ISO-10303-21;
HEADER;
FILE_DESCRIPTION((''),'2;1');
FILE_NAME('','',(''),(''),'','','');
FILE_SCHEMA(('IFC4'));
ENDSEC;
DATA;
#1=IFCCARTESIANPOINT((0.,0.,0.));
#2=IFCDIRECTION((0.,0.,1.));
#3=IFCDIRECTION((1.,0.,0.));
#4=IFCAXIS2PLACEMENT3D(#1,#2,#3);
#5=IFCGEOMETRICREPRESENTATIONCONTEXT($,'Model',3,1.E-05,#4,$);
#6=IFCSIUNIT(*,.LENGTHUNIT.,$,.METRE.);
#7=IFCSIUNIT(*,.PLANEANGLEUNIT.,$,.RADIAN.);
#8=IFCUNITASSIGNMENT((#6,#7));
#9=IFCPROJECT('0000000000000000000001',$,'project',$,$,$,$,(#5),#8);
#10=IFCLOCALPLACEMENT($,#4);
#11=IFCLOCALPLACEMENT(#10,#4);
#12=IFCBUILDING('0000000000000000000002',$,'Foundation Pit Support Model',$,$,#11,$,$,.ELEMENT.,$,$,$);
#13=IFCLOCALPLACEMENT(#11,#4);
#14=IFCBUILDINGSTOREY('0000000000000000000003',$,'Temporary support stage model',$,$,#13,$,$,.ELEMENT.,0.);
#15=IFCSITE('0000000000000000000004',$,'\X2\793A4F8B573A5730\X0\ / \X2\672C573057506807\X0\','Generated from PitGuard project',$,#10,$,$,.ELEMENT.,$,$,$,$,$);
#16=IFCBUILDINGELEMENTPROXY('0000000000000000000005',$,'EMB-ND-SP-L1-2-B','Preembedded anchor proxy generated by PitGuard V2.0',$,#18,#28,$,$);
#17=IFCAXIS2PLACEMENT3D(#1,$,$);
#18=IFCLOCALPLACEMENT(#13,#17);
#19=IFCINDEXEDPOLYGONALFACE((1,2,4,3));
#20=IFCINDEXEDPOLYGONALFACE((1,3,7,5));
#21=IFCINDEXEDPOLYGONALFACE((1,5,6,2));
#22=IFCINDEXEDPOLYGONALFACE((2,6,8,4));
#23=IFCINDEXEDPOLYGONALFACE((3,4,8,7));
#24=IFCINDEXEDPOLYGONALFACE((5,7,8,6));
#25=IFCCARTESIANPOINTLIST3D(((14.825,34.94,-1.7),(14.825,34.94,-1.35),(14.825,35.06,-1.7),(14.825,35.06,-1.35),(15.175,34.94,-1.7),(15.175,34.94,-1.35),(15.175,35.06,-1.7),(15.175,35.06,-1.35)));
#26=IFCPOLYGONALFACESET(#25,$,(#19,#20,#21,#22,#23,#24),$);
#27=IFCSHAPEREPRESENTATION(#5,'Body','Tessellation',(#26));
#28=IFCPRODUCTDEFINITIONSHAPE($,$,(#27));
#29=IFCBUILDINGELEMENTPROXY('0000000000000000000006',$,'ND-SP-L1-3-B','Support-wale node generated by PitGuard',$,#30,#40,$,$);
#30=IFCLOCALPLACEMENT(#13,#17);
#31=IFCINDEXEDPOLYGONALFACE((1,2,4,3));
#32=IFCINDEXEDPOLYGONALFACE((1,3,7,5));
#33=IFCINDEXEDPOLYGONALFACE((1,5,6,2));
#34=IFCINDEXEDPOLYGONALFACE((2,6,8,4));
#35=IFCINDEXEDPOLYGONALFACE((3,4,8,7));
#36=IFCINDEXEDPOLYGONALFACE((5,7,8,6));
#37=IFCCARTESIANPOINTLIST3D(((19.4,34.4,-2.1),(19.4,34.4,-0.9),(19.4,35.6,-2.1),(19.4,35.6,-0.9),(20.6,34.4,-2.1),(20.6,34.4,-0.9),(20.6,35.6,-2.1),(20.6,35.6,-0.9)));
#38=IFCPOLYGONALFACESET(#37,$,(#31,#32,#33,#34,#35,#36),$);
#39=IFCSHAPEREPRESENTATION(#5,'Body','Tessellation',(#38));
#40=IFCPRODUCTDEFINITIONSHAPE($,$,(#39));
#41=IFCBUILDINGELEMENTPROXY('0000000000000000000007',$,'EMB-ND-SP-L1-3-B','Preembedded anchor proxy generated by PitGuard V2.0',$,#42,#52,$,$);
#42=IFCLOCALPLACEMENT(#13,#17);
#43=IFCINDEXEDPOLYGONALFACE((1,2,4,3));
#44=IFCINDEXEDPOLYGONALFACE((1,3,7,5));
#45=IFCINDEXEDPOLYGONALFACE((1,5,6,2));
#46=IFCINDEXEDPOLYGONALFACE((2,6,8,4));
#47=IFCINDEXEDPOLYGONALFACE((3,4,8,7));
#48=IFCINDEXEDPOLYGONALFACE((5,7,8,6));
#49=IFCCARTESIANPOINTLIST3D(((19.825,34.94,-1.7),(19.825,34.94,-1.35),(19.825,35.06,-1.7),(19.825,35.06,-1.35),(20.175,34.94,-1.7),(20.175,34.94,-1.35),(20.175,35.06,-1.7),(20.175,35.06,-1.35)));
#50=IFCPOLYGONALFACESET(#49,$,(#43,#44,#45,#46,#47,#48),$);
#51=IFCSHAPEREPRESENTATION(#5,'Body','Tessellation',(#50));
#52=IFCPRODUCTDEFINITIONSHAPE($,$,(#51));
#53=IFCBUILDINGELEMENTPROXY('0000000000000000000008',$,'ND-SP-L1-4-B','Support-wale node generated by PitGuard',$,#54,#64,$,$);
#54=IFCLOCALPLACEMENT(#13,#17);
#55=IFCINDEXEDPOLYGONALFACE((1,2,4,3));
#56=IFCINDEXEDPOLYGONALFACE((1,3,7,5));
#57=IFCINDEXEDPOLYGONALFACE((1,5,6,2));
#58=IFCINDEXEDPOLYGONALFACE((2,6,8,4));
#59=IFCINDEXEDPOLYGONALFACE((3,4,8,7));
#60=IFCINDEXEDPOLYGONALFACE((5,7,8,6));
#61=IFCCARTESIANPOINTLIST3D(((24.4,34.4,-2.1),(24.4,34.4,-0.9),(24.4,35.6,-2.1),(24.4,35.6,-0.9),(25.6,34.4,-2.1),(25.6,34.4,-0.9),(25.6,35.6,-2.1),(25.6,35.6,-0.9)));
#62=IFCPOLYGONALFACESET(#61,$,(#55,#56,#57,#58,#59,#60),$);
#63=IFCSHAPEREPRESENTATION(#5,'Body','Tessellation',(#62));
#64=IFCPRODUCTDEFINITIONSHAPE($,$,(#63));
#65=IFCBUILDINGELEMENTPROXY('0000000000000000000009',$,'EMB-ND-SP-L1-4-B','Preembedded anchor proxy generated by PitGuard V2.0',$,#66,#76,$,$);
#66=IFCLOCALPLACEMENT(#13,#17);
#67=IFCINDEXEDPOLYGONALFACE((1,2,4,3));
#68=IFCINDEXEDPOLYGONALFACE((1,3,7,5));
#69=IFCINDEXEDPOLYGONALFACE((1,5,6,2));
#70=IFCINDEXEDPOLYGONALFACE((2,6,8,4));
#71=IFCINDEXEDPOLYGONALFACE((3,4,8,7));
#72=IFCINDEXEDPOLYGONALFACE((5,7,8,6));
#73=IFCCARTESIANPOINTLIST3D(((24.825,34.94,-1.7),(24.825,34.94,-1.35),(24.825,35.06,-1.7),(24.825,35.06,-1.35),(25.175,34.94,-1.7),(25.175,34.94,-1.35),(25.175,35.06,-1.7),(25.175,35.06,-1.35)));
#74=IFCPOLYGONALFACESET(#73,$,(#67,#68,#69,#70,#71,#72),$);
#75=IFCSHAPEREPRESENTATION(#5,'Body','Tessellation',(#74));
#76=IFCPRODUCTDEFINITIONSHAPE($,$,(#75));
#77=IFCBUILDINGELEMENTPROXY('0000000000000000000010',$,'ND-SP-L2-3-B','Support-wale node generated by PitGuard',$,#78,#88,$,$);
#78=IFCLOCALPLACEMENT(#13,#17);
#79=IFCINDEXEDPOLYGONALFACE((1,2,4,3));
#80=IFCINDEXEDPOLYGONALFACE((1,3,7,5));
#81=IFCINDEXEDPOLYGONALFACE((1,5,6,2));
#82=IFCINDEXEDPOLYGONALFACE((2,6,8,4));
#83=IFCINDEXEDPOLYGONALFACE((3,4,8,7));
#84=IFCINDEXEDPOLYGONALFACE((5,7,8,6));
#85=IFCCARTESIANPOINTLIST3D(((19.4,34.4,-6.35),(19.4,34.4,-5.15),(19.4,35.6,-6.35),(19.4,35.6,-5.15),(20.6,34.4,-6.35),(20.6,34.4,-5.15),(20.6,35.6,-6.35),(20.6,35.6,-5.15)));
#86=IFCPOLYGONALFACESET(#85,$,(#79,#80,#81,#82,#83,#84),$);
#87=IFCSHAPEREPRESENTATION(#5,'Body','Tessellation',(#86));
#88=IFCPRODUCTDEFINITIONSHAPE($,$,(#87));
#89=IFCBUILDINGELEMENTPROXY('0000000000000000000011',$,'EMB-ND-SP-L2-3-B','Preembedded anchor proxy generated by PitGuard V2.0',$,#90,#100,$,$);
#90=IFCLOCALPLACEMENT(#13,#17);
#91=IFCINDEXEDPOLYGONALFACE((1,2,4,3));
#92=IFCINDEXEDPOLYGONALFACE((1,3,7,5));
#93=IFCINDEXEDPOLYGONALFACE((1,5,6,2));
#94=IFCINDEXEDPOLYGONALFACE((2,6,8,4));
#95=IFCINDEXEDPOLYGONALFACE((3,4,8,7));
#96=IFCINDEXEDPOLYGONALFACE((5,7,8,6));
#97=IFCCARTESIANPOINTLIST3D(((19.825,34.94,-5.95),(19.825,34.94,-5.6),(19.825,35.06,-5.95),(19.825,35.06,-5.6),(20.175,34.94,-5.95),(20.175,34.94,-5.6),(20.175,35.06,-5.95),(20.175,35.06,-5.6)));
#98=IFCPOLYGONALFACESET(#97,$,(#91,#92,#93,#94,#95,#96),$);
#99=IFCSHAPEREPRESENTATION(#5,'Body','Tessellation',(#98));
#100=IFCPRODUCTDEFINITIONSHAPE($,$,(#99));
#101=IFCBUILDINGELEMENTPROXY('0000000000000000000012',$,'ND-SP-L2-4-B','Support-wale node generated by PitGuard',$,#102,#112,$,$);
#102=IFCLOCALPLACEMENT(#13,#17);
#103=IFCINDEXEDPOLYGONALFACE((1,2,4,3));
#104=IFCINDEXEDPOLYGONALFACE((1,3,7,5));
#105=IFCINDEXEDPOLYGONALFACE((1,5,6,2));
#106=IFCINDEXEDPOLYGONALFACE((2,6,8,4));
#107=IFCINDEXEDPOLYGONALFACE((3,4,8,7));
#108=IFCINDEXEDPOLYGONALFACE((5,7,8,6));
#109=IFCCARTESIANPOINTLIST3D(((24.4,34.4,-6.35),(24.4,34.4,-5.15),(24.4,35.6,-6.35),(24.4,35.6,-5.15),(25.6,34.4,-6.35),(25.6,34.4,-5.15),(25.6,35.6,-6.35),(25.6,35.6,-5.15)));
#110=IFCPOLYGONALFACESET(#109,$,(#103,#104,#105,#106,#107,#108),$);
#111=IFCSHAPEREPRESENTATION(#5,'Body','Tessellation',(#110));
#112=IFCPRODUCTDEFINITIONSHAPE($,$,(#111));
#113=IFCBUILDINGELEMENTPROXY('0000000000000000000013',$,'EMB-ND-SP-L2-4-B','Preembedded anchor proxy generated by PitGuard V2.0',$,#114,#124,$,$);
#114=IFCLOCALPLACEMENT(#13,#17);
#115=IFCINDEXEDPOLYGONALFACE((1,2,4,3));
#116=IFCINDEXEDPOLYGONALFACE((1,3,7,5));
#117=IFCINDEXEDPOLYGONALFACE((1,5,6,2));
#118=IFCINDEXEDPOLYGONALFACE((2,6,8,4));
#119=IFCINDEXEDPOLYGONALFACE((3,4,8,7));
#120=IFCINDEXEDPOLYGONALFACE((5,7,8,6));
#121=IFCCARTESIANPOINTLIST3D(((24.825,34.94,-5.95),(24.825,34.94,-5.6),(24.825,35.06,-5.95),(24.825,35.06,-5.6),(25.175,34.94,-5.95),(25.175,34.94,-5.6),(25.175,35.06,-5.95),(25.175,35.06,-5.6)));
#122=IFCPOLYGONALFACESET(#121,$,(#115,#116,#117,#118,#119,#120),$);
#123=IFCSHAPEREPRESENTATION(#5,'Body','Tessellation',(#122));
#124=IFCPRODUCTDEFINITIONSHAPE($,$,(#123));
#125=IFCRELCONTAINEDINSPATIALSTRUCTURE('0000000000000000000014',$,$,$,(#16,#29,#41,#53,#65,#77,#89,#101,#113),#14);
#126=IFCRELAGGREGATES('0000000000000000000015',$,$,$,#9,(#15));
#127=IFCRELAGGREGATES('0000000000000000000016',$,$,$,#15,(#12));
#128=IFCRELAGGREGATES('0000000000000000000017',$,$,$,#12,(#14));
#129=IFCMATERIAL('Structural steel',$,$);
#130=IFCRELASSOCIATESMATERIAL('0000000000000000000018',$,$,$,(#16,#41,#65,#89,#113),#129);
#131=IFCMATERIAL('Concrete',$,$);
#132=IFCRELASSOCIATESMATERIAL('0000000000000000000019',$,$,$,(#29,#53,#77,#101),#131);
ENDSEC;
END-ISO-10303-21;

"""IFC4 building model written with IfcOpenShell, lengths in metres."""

from ifc_helpers import new_model, si_unit, frame, origin_with_axes, origin_2d, place, context, project, spatial, rectangle, extrude, material, element, save


model = new_model("IFC4")

# Units and contexts
model_context = context("Model", 3, precision=1e-05, world=origin_with_axes())
ifc_project = project(units=[si_unit("LENGTHUNIT", "METRE"), si_unit("PLANEANGLEUNIT", "RADIAN")], contexts=[model_context])

# Site, building, storey
site_placement = place(None, origin_with_axes())
site = spatial("IfcSite", under=ifc_project, at=site_placement, Name="示例场地 / 本地坐标", Description="Generated from PitGuard project", CompositionType="ELEMENT")
building_placement = place(site_placement, origin_with_axes())
building = spatial("IfcBuilding", under=site, at=building_placement, Name="Foundation Pit Support Model", CompositionType="ELEMENT")
storey_placement = place(building_placement, origin_with_axes())
storey = spatial("IfcBuildingStorey", under=building, at=storey_placement, Name="Temporary support stage model", CompositionType="ELEMENT", Elevation=0.0)

# Shared definitions
ifc_material_1 = material(Name="Concrete")

# Shared definitions
ifc_material_2 = material(Name="Structural steel")

# Building element proxies
proxy_1_placement = place(storey_placement, frame((15.0, 35.0, -1.7), z_axis=(0.0, 0.0, 1.0), x_axis=(1.0, 0.0, 0.0)))
element("IfcBuildingElementProxy", 1, at=proxy_1_placement, inside=storey, material=ifc_material_2, Name="EMB-ND-SP-L1-2-B", Description="Preembedded anchor proxy generated by PitGuard V2.0", context=model_context, shape_type="SweptSolid", body=[
    extrude(rectangle(XDim=0.35, YDim=0.12, at=origin_2d()), origin_with_axes(), (0.0, 0.0, 1.0), 0.35),
])
proxy_2_placement = place(storey_placement, frame((20.0, 35.0, -2.1), z_axis=(0.0, 0.0, 1.0), x_axis=(1.0, 0.0, 0.0)))
element("IfcBuildingElementProxy", 2, at=proxy_2_placement, inside=storey, material=ifc_material_1, Name="ND-SP-L1-3-B", Description="Support-wale node generated by PitGuard", context=model_context, shape_type="SweptSolid", body=[
    extrude(rectangle(XDim=1.2, YDim=1.2, at=origin_2d()), origin_with_axes(), (0.0, 0.0, 1.0), 1.2),
])
proxy_3_placement = place(storey_placement, frame((20.0, 35.0, -1.7), z_axis=(0.0, 0.0, 1.0), x_axis=(1.0, 0.0, 0.0)))
element("IfcBuildingElementProxy", 3, at=proxy_3_placement, inside=storey, material=ifc_material_2, Name="EMB-ND-SP-L1-3-B", Description="Preembedded anchor proxy generated by PitGuard V2.0", context=model_context, shape_type="SweptSolid", body=[
    extrude(rectangle(XDim=0.35, YDim=0.12, at=origin_2d()), origin_with_axes(), (0.0, 0.0, 1.0), 0.35),
])
proxy_4_placement = place(storey_placement, frame((25.0, 35.0, -2.1), z_axis=(0.0, 0.0, 1.0), x_axis=(1.0, 0.0, 0.0)))
element("IfcBuildingElementProxy", 4, at=proxy_4_placement, inside=storey, material=ifc_material_1, Name="ND-SP-L1-4-B", Description="Support-wale node generated by PitGuard", context=model_context, shape_type="SweptSolid", body=[
    extrude(rectangle(XDim=1.2, YDim=1.2, at=origin_2d()), origin_with_axes(), (0.0, 0.0, 1.0), 1.2),
])
proxy_5_placement = place(storey_placement, frame((25.0, 35.0, -1.7), z_axis=(0.0, 0.0, 1.0), x_axis=(1.0, 0.0, 0.0)))
element("IfcBuildingElementProxy", 5, at=proxy_5_placement, inside=storey, material=ifc_material_2, Name="EMB-ND-SP-L1-4-B", Description="Preembedded anchor proxy generated by PitGuard V2.0", context=model_context, shape_type="SweptSolid", body=[
    extrude(rectangle(XDim=0.35, YDim=0.12, at=origin_2d()), origin_with_axes(), (0.0, 0.0, 1.0), 0.35),
])
proxy_6_placement = place(storey_placement, frame((20.0, 35.0, -6.35), z_axis=(0.0, 0.0, 1.0), x_axis=(1.0, 0.0, 0.0)))
element("IfcBuildingElementProxy", 6, at=proxy_6_placement, inside=storey, material=ifc_material_1, Name="ND-SP-L2-3-B", Description="Support-wale node generated by PitGuard", context=model_context, shape_type="SweptSolid", body=[
    extrude(rectangle(XDim=1.2, YDim=1.2, at=origin_2d()), origin_with_axes(), (0.0, 0.0, 1.0), 1.2),
])
proxy_7_placement = place(storey_placement, frame((20.0, 35.0, -5.95), z_axis=(0.0, 0.0, 1.0), x_axis=(1.0, 0.0, 0.0)))
element("IfcBuildingElementProxy", 7, at=proxy_7_placement, inside=storey, material=ifc_material_2, Name="EMB-ND-SP-L2-3-B", Description="Preembedded anchor proxy generated by PitGuard V2.0", context=model_context, shape_type="SweptSolid", body=[
    extrude(rectangle(XDim=0.35, YDim=0.12, at=origin_2d()), origin_with_axes(), (0.0, 0.0, 1.0), 0.35),
])
proxy_8_placement = place(storey_placement, frame((25.0, 35.0, -6.35), z_axis=(0.0, 0.0, 1.0), x_axis=(1.0, 0.0, 0.0)))
element("IfcBuildingElementProxy", 8, at=proxy_8_placement, inside=storey, material=ifc_material_1, Name="ND-SP-L2-4-B", Description="Support-wale node generated by PitGuard", context=model_context, shape_type="SweptSolid", body=[
    extrude(rectangle(XDim=1.2, YDim=1.2, at=origin_2d()), origin_with_axes(), (0.0, 0.0, 1.0), 1.2),
])
proxy_9_placement = place(storey_placement, frame((25.0, 35.0, -5.95), z_axis=(0.0, 0.0, 1.0), x_axis=(1.0, 0.0, 0.0)))
element("IfcBuildingElementProxy", 9, at=proxy_9_placement, inside=storey, material=ifc_material_2, Name="EMB-ND-SP-L2-4-B", Description="Preembedded anchor proxy generated by PitGuard V2.0", context=model_context, shape_type="SweptSolid", body=[
    extrude(rectangle(XDim=0.35, YDim=0.12, at=origin_2d()), origin_with_axes(), (0.0, 0.0, 1.0), 0.35),
])

save(model, "model.ifc")
